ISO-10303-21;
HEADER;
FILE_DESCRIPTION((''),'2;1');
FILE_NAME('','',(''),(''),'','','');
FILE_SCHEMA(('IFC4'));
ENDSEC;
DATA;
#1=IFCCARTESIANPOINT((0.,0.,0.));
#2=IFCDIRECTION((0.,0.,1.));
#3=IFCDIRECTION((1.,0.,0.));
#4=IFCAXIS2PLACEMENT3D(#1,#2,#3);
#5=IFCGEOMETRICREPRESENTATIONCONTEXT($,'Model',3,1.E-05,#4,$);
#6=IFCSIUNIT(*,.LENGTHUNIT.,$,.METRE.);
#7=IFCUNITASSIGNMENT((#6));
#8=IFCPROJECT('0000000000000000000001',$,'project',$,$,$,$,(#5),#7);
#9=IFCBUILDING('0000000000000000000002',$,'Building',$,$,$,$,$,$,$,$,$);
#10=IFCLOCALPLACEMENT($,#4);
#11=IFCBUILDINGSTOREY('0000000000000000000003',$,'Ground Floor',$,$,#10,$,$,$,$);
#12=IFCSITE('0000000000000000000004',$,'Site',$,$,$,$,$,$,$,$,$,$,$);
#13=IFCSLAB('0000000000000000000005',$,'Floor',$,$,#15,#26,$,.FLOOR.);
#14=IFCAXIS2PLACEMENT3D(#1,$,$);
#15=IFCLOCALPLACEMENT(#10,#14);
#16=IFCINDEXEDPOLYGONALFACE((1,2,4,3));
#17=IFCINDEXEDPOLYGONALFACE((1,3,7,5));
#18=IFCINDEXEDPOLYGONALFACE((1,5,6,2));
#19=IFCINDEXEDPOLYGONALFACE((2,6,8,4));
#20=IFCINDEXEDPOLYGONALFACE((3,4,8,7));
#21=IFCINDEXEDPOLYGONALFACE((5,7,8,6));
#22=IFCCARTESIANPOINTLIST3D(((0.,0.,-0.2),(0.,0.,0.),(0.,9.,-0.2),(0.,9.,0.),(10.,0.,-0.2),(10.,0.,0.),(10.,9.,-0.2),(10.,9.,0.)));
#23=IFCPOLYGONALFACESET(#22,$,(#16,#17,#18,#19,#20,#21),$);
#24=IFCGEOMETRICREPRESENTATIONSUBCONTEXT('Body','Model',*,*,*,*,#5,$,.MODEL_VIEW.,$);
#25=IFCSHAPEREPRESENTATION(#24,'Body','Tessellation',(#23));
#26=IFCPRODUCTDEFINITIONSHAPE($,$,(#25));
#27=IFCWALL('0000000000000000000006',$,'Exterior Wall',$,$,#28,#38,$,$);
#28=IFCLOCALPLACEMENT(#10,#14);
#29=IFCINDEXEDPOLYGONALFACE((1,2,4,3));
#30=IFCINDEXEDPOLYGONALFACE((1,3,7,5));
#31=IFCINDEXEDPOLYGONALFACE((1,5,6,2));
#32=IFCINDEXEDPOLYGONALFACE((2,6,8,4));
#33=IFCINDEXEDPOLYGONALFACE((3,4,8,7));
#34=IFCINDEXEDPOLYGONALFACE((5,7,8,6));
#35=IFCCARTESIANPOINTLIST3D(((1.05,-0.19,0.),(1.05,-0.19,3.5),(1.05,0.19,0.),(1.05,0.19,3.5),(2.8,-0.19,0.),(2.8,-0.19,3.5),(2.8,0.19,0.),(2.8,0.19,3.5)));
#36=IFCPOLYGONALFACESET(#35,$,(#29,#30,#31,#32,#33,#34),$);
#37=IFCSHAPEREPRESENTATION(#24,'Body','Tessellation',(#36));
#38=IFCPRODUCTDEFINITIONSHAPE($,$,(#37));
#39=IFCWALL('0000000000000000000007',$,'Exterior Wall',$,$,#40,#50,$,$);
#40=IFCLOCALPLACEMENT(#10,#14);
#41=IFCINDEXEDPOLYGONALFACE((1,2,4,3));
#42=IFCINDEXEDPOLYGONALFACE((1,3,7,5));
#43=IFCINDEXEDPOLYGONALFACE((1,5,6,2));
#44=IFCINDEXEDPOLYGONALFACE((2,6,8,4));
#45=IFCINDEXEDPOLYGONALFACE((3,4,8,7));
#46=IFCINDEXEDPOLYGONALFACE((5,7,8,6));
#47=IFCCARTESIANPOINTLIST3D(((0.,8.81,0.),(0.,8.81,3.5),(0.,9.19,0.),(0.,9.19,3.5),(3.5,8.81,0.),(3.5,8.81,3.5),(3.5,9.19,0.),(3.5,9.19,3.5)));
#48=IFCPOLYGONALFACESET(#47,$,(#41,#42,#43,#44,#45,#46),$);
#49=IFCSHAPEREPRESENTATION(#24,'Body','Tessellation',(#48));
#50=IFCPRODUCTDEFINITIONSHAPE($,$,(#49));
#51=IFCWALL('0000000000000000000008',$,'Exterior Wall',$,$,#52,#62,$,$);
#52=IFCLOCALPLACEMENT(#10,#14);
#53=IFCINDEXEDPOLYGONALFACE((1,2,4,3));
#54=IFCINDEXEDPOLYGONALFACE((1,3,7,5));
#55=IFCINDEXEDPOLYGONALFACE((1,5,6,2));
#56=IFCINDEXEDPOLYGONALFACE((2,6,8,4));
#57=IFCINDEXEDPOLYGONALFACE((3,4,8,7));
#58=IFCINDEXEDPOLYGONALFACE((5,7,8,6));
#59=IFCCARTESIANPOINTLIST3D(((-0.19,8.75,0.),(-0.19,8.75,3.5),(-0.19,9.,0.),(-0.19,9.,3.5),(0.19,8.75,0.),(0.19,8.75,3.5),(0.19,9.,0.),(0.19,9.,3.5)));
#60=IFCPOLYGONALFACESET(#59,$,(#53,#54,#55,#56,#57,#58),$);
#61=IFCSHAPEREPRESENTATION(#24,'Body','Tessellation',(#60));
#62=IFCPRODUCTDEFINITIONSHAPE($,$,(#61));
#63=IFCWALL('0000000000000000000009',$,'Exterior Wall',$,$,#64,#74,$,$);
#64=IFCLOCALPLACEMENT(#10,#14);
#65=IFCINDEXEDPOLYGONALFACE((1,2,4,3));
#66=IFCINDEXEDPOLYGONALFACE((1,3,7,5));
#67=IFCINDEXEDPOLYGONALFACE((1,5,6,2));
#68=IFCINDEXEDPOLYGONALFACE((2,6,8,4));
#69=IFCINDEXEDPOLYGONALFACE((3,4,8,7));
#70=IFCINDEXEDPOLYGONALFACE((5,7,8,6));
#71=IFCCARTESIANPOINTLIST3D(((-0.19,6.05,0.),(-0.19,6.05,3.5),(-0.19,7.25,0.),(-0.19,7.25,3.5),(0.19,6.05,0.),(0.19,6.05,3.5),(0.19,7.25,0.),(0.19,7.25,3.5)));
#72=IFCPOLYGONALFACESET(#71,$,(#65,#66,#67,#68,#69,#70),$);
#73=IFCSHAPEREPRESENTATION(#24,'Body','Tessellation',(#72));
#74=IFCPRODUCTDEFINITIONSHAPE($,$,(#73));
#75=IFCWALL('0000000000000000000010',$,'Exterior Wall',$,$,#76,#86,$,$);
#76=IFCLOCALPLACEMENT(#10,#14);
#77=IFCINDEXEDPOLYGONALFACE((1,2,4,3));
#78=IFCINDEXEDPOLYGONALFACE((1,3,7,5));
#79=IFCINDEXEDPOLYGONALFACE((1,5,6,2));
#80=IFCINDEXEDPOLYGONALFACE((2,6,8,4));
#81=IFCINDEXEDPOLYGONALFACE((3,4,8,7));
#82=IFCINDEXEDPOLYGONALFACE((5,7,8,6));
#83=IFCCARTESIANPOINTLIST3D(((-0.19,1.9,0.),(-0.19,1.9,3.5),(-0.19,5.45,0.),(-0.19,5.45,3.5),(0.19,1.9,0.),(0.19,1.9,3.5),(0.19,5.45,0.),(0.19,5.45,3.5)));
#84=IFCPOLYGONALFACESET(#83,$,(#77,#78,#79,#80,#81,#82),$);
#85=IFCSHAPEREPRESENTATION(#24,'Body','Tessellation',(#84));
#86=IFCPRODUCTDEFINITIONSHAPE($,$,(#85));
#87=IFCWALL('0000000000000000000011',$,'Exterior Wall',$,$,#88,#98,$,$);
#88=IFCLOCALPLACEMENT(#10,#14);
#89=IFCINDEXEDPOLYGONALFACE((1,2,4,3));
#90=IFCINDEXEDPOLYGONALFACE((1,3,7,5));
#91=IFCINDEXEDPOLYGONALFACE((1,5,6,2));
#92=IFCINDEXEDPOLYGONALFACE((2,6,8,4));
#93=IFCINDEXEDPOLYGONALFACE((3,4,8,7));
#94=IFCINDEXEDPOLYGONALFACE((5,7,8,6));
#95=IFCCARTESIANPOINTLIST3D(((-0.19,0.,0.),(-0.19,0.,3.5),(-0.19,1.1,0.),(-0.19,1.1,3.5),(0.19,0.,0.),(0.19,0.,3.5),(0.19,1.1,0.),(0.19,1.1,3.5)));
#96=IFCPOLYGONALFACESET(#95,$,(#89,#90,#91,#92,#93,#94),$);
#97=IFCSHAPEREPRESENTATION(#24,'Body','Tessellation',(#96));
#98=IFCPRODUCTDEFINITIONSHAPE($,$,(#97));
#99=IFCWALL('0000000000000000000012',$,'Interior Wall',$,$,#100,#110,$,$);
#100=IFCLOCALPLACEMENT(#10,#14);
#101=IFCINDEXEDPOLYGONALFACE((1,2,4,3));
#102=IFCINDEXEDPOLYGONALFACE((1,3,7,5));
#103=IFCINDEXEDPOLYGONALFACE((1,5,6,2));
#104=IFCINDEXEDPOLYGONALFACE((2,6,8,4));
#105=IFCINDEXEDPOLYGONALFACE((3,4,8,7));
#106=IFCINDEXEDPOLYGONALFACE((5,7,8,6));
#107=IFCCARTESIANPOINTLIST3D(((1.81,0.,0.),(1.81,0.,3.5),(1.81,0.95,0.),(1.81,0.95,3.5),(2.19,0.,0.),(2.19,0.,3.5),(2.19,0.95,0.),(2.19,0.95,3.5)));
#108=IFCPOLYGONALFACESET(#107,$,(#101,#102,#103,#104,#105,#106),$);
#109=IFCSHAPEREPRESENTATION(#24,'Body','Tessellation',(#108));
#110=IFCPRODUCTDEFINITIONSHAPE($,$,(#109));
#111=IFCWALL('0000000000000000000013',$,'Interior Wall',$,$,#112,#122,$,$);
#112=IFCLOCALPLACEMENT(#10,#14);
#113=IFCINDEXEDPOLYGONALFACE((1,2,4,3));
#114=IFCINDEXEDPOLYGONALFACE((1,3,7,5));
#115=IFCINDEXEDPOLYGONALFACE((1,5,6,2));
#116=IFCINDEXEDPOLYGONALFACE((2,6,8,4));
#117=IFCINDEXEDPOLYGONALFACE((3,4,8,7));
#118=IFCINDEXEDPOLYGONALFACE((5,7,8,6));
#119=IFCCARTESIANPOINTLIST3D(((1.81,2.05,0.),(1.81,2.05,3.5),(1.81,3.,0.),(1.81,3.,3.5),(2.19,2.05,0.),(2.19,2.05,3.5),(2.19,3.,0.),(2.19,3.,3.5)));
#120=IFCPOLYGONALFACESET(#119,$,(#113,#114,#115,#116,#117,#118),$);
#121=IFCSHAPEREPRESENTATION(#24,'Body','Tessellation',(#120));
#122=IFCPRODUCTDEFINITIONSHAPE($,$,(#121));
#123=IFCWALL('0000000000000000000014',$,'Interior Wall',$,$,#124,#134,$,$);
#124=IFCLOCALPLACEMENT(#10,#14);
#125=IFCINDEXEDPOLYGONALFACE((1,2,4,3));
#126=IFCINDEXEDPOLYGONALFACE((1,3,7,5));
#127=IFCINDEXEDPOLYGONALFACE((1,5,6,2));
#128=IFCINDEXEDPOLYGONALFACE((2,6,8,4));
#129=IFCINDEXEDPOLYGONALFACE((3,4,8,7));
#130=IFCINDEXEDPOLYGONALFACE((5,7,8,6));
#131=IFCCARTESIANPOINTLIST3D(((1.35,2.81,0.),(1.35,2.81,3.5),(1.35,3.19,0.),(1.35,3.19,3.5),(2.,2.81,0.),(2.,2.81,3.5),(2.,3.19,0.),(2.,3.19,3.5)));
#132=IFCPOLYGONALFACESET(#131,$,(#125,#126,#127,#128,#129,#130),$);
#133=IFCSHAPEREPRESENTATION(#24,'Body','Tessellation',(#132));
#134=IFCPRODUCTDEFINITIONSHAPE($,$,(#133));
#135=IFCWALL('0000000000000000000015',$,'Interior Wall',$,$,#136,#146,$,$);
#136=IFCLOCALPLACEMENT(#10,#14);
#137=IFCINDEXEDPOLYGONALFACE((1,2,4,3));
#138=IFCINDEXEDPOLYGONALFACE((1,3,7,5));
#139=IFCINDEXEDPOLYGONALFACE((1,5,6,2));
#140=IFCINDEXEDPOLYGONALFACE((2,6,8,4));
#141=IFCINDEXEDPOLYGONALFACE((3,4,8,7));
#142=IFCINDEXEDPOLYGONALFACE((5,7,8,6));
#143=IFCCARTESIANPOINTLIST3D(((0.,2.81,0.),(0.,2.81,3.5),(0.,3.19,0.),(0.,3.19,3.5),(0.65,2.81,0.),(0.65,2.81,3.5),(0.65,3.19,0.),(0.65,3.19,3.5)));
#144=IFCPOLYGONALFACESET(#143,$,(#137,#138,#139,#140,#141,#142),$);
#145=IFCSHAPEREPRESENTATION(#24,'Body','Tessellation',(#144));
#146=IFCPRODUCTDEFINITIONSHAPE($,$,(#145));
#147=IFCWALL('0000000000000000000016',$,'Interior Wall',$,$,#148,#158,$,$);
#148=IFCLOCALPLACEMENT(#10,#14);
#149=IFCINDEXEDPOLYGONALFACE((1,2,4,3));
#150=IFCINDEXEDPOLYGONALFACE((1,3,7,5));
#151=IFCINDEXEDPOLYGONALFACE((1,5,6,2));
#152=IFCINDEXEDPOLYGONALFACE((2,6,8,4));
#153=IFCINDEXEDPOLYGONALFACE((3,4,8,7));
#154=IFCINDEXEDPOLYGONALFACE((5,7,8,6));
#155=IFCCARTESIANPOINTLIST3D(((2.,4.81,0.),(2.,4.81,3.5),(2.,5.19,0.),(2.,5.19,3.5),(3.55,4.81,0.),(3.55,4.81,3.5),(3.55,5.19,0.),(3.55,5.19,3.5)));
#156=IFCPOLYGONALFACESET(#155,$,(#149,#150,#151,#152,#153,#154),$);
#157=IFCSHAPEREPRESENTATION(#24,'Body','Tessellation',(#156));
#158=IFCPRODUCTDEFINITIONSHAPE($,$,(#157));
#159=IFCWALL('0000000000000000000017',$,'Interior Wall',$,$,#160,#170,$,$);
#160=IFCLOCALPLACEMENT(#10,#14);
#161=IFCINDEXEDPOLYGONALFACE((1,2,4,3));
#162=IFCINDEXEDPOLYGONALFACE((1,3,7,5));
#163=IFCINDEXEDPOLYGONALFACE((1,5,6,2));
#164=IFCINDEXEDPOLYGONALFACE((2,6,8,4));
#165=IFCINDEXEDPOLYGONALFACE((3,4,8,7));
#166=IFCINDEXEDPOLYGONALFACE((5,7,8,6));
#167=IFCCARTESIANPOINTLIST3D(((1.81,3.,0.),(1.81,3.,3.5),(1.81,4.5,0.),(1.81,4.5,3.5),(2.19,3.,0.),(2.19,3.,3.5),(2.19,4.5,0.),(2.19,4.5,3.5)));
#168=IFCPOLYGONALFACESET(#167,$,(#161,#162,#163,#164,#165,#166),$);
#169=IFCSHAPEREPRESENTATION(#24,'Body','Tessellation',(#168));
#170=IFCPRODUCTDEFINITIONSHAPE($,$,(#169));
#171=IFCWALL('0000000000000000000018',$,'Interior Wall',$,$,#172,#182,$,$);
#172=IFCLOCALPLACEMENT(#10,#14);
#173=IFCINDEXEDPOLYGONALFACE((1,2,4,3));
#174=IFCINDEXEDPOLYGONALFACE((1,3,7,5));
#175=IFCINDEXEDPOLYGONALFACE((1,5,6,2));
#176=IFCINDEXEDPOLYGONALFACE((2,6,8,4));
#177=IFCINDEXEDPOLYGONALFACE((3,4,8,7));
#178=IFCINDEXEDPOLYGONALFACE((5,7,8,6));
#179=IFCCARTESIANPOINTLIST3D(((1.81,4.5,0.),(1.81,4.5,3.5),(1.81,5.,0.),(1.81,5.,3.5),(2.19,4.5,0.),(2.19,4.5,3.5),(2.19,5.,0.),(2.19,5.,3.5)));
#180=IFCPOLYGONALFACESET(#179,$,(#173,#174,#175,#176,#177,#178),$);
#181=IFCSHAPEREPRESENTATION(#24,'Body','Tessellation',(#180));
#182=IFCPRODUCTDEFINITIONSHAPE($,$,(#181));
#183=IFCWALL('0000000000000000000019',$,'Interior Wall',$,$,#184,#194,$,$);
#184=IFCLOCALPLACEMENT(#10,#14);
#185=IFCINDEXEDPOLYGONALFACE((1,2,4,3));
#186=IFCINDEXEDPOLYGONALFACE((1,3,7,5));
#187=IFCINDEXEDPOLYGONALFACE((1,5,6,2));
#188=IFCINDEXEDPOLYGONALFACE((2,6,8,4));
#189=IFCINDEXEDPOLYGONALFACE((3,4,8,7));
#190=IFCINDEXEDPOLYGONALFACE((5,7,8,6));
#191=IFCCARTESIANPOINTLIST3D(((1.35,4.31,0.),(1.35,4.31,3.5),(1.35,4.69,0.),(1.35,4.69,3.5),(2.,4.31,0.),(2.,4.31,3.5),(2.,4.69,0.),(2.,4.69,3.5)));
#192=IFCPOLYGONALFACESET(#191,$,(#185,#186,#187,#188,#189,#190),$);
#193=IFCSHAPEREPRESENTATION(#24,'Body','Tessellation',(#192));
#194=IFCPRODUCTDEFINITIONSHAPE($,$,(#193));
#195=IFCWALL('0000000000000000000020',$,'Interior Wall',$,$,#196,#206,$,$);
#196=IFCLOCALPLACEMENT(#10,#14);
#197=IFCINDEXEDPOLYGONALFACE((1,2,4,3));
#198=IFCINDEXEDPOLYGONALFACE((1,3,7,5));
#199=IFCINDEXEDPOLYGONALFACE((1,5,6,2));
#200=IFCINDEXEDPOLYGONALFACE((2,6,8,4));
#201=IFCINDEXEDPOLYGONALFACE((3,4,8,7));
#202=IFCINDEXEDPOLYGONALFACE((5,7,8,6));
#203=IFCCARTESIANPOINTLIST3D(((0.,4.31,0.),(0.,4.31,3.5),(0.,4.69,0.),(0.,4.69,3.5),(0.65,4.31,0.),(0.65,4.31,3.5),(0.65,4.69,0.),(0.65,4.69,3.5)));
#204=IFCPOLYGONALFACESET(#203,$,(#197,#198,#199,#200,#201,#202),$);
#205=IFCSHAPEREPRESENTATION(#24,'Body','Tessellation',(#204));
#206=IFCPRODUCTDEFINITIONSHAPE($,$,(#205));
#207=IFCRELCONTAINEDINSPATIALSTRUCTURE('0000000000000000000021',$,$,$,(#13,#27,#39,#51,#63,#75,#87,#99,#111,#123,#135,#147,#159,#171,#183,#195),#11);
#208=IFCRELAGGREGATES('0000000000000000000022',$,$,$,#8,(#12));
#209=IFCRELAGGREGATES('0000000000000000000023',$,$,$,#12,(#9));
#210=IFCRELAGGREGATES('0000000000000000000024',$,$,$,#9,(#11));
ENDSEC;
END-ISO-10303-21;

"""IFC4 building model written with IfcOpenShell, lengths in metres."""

from ifc_helpers import new_model, si_unit, frame, origin_with_axes, place, context, subcontext, project, spatial, indexed_curve, outline, extrude, element, save


model = new_model("IFC4")

# Units and contexts
model_context = context("Model", 3, precision=1e-05, world=origin_with_axes())
body_context = subcontext(model_context, "Body", "Model", "MODEL_VIEW")
ifc_project = project(units=[si_unit("LENGTHUNIT", "METRE")], contexts=[model_context])

# Site, building, storey
site = spatial("IfcSite", under=ifc_project, Name="Site")
building = spatial("IfcBuilding", under=site, Name="Building")
storey_placement = place(None, origin_with_axes())
storey = spatial("IfcBuildingStorey", under=building, at=storey_placement, Name="Ground Floor")

# Slab
slab_placement = place(storey_placement, frame((0.0, 0.0, -0.2), z_axis=(0.0, 0.0, 1.0), x_axis=(1.0, 0.0, 0.0)))
element("IfcSlab", 1, at=slab_placement, inside=storey, Name="Floor", PredefinedType="FLOOR", context=body_context, shape_type="SweptSolid", body=[
    extrude(outline(indexed_curve([(0.0, 0.0), (10.0, 0.0), (10.0, 9.0), (0.0, 9.0)])), None, (0.0, 0.0, 1.0), 0.2),
])

# Walls
wall_1_placement = place(storey_placement, frame((1.05, 0.0, 0.0), z_axis=(0.0, 0.0, 1.0), x_axis=(1.0, 0.0, 0.0)))
element("IfcWall", 2, at=wall_1_placement, inside=storey, Name="Exterior Wall", context=body_context, shape_type="SweptSolid", body=[
    extrude(outline(indexed_curve([(0.0, 0.0), (0.0, 0.38), (1.75, 0.38), (1.75, 0.0), (0.0, 0.0)], self_intersect=False)), frame((0.0, -0.19, 0.0), z_axis=(0.0, 0.0, 1.0), x_axis=(1.0, 0.0, 0.0)), (0.0, 0.0, 1.0), 3.5),
])
wall_2_placement = place(storey_placement, frame((3.5, 9.0, 0.0), z_axis=(0.0, 0.0, 1.0), x_axis=(-1.0, 0.0, 0.0)))
element("IfcWall", 3, at=wall_2_placement, inside=storey, Name="Exterior Wall", context=body_context, shape_type="SweptSolid", body=[
    extrude(outline(indexed_curve([(0.0, 0.0), (0.0, 0.38), (3.5, 0.38), (3.5, 0.0), (0.0, 0.0)], self_intersect=False)), frame((0.0, -0.19, 0.0), z_axis=(0.0, 0.0, 1.0), x_axis=(1.0, 0.0, 0.0)), (0.0, 0.0, 1.0), 3.5),
])
wall_3_placement = place(storey_placement, frame((0.0, 9.0, 0.0), z_axis=(0.0, 0.0, 1.0), x_axis=(0.0, -1.0, 0.0)))
element("IfcWall", 4, at=wall_3_placement, inside=storey, Name="Exterior Wall", context=body_context, shape_type="SweptSolid", body=[
    extrude(outline(indexed_curve([(0.0, 0.0), (0.0, 0.38), (0.25, 0.38), (0.25, 0.0), (0.0, 0.0)], self_intersect=False)), frame((0.0, -0.19, 0.0), z_axis=(0.0, 0.0, 1.0), x_axis=(1.0, 0.0, 0.0)), (0.0, 0.0, 1.0), 3.5),
])
wall_4_placement = place(storey_placement, frame((0.0, 7.25, 0.0), z_axis=(0.0, 0.0, 1.0), x_axis=(0.0, -1.0, 0.0)))
element("IfcWall", 5, at=wall_4_placement, inside=storey, Name="Exterior Wall", context=body_context, shape_type="SweptSolid", body=[
    extrude(outline(indexed_curve([(0.0, 0.0), (0.0, 0.38), (1.2, 0.38), (1.2, 0.0), (0.0, 0.0)], self_intersect=False)), frame((0.0, -0.19, 0.0), z_axis=(0.0, 0.0, 1.0), x_axis=(1.0, 0.0, 0.0)), (0.0, 0.0, 1.0), 3.5),
])
wall_5_placement = place(storey_placement, frame((0.0, 5.45, 0.0), z_axis=(0.0, 0.0, 1.0), x_axis=(0.0, -1.0, 0.0)))
element("IfcWall", 6, at=wall_5_placement, inside=storey, Name="Exterior Wall", context=body_context, shape_type="SweptSolid", body=[
    extrude(outline(indexed_curve([(0.0, 0.0), (0.0, 0.38), (3.55, 0.38), (3.55, 0.0), (0.0, 0.0)], self_intersect=False)), frame((0.0, -0.19, 0.0), z_axis=(0.0, 0.0, 1.0), x_axis=(1.0, 0.0, 0.0)), (0.0, 0.0, 1.0), 3.5),
])
wall_6_placement = place(storey_placement, frame((0.0, 1.1, 0.0), z_axis=(0.0, 0.0, 1.0), x_axis=(0.0, -1.0, 0.0)))
element("IfcWall", 7, at=wall_6_placement, inside=storey, Name="Exterior Wall", context=body_context, shape_type="SweptSolid", body=[
    extrude(outline(indexed_curve([(0.0, 0.0), (0.0, 0.38), (1.1, 0.38), (1.1, 0.0), (0.0, 0.0)], self_intersect=False)), frame((0.0, -0.19, 0.0), z_axis=(0.0, 0.0, 1.0), x_axis=(1.0, 0.0, 0.0)), (0.0, 0.0, 1.0), 3.5),
])
wall_7_placement = place(storey_placement, frame((2.0, 0.0, 0.0), z_axis=(0.0, 0.0, 1.0), x_axis=(0.0, 1.0, 0.0)))
element("IfcWall", 8, at=wall_7_placement, inside=storey, Name="Interior Wall", context=body_context, shape_type="SweptSolid", body=[
    extrude(outline(indexed_curve([(0.0, 0.0), (0.0, 0.38), (0.95, 0.38), (0.95, 0.0), (0.0, 0.0)], self_intersect=False)), frame((0.0, -0.19, 0.0), z_axis=(0.0, 0.0, 1.0), x_axis=(1.0, 0.0, 0.0)), (0.0, 0.0, 1.0), 3.5),
])
wall_8_placement = place(storey_placement, frame((2.0, 2.05, 0.0), z_axis=(0.0, 0.0, 1.0), x_axis=(0.0, 1.0, 0.0)))
element("IfcWall", 9, at=wall_8_placement, inside=storey, Name="Interior Wall", context=body_context, shape_type="SweptSolid", body=[
    extrude(outline(indexed_curve([(0.0, 0.0), (0.0, 0.38), (0.95, 0.38), (0.95, 0.0), (0.0, 0.0)], self_intersect=False)), frame((0.0, -0.19, 0.0), z_axis=(0.0, 0.0, 1.0), x_axis=(1.0, 0.0, 0.0)), (0.0, 0.0, 1.0), 3.5),
])
for number, where, z_axis, x_axis, name in (
    (10, (2.0, 3.0, 0.0), (0.0, 0.0, 1.0), (-1.0, 0.0, 0.0), "Interior Wall"),
    (11, (0.65, 3.0, 0.0), (0.0, 0.0, 1.0), (-1.0, 0.0, 0.0), "Interior Wall"),
):
    element("IfcWall", number, at=place(storey_placement, frame(where, z_axis=z_axis, x_axis=x_axis)), inside=storey, Name=name, context=body_context, shape_type="SweptSolid", body=[
        extrude(outline(indexed_curve([(0.0, 0.0), (0.0, 0.38), (0.65, 0.38), (0.65, 0.0), (0.0, 0.0)], self_intersect=False)), frame((0.0, -0.19, 0.0), z_axis=(0.0, 0.0, 1.0), x_axis=(1.0, 0.0, 0.0)), (0.0, 0.0, 1.0), 3.5),
    ])
wall_9_placement = place(storey_placement, frame((3.55, 5.0, 0.0), z_axis=(0.0, 0.0, 1.0), x_axis=(-1.0, 0.0, 0.0)))
element("IfcWall", 12, at=wall_9_placement, inside=storey, Name="Interior Wall", context=body_context, shape_type="SweptSolid", body=[
    extrude(outline(indexed_curve([(0.0, 0.0), (0.0, 0.38), (1.55, 0.38), (1.55, 0.0), (0.0, 0.0)], self_intersect=False)), frame((0.0, -0.19, 0.0), z_axis=(0.0, 0.0, 1.0), x_axis=(1.0, 0.0, 0.0)), (0.0, 0.0, 1.0), 3.5),
])
wall_10_placement = place(storey_placement, frame((2.0, 4.5, 0.0), z_axis=(0.0, 0.0, 1.0), x_axis=(0.0, -1.0, 0.0)))
element("IfcWall", 13, at=wall_10_placement, inside=storey, Name="Interior Wall", context=body_context, shape_type="SweptSolid", body=[
    extrude(outline(indexed_curve([(0.0, 0.0), (0.0, 0.38), (1.5, 0.38), (1.5, 0.0), (0.0, 0.0)], self_intersect=False)), frame((0.0, -0.19, 0.0), z_axis=(0.0, 0.0, 1.0), x_axis=(1.0, 0.0, 0.0)), (0.0, 0.0, 1.0), 3.5),
])
wall_11_placement = place(storey_placement, frame((2.0, 5.0, 0.0), z_axis=(0.0, 0.0, 1.0), x_axis=(0.0, -1.0, 0.0)))
element("IfcWall", 14, at=wall_11_placement, inside=storey, Name="Interior Wall", context=body_context, shape_type="SweptSolid", body=[
    extrude(outline(indexed_curve([(0.0, 0.0), (0.0, 0.38), (0.5, 0.38), (0.5, 0.0), (0.0, 0.0)], self_intersect=False)), frame((0.0, -0.19, 0.0), z_axis=(0.0, 0.0, 1.0), x_axis=(1.0, 0.0, 0.0)), (0.0, 0.0, 1.0), 3.5),
])
for number, where, z_axis, x_axis, name in (
    (15, (2.0, 4.5, 0.0), (0.0, 0.0, 1.0), (-1.0, 0.0, 0.0), "Interior Wall"),
    (16, (0.65, 4.5, 0.0), (0.0, 0.0, 1.0), (-1.0, 0.0, 0.0), "Interior Wall"),
):
    element("IfcWall", number, at=place(storey_placement, frame(where, z_axis=z_axis, x_axis=x_axis)), inside=storey, Name=name, context=body_context, shape_type="SweptSolid", body=[
        extrude(outline(indexed_curve([(0.0, 0.0), (0.0, 0.38), (0.65, 0.38), (0.65, 0.0), (0.0, 0.0)], self_intersect=False)), frame((0.0, -0.19, 0.0), z_axis=(0.0, 0.0, 1.0), x_axis=(1.0, 0.0, 0.0)), (0.0, 0.0, 1.0), 3.5),
    ])

save(model, "model.ifc")
